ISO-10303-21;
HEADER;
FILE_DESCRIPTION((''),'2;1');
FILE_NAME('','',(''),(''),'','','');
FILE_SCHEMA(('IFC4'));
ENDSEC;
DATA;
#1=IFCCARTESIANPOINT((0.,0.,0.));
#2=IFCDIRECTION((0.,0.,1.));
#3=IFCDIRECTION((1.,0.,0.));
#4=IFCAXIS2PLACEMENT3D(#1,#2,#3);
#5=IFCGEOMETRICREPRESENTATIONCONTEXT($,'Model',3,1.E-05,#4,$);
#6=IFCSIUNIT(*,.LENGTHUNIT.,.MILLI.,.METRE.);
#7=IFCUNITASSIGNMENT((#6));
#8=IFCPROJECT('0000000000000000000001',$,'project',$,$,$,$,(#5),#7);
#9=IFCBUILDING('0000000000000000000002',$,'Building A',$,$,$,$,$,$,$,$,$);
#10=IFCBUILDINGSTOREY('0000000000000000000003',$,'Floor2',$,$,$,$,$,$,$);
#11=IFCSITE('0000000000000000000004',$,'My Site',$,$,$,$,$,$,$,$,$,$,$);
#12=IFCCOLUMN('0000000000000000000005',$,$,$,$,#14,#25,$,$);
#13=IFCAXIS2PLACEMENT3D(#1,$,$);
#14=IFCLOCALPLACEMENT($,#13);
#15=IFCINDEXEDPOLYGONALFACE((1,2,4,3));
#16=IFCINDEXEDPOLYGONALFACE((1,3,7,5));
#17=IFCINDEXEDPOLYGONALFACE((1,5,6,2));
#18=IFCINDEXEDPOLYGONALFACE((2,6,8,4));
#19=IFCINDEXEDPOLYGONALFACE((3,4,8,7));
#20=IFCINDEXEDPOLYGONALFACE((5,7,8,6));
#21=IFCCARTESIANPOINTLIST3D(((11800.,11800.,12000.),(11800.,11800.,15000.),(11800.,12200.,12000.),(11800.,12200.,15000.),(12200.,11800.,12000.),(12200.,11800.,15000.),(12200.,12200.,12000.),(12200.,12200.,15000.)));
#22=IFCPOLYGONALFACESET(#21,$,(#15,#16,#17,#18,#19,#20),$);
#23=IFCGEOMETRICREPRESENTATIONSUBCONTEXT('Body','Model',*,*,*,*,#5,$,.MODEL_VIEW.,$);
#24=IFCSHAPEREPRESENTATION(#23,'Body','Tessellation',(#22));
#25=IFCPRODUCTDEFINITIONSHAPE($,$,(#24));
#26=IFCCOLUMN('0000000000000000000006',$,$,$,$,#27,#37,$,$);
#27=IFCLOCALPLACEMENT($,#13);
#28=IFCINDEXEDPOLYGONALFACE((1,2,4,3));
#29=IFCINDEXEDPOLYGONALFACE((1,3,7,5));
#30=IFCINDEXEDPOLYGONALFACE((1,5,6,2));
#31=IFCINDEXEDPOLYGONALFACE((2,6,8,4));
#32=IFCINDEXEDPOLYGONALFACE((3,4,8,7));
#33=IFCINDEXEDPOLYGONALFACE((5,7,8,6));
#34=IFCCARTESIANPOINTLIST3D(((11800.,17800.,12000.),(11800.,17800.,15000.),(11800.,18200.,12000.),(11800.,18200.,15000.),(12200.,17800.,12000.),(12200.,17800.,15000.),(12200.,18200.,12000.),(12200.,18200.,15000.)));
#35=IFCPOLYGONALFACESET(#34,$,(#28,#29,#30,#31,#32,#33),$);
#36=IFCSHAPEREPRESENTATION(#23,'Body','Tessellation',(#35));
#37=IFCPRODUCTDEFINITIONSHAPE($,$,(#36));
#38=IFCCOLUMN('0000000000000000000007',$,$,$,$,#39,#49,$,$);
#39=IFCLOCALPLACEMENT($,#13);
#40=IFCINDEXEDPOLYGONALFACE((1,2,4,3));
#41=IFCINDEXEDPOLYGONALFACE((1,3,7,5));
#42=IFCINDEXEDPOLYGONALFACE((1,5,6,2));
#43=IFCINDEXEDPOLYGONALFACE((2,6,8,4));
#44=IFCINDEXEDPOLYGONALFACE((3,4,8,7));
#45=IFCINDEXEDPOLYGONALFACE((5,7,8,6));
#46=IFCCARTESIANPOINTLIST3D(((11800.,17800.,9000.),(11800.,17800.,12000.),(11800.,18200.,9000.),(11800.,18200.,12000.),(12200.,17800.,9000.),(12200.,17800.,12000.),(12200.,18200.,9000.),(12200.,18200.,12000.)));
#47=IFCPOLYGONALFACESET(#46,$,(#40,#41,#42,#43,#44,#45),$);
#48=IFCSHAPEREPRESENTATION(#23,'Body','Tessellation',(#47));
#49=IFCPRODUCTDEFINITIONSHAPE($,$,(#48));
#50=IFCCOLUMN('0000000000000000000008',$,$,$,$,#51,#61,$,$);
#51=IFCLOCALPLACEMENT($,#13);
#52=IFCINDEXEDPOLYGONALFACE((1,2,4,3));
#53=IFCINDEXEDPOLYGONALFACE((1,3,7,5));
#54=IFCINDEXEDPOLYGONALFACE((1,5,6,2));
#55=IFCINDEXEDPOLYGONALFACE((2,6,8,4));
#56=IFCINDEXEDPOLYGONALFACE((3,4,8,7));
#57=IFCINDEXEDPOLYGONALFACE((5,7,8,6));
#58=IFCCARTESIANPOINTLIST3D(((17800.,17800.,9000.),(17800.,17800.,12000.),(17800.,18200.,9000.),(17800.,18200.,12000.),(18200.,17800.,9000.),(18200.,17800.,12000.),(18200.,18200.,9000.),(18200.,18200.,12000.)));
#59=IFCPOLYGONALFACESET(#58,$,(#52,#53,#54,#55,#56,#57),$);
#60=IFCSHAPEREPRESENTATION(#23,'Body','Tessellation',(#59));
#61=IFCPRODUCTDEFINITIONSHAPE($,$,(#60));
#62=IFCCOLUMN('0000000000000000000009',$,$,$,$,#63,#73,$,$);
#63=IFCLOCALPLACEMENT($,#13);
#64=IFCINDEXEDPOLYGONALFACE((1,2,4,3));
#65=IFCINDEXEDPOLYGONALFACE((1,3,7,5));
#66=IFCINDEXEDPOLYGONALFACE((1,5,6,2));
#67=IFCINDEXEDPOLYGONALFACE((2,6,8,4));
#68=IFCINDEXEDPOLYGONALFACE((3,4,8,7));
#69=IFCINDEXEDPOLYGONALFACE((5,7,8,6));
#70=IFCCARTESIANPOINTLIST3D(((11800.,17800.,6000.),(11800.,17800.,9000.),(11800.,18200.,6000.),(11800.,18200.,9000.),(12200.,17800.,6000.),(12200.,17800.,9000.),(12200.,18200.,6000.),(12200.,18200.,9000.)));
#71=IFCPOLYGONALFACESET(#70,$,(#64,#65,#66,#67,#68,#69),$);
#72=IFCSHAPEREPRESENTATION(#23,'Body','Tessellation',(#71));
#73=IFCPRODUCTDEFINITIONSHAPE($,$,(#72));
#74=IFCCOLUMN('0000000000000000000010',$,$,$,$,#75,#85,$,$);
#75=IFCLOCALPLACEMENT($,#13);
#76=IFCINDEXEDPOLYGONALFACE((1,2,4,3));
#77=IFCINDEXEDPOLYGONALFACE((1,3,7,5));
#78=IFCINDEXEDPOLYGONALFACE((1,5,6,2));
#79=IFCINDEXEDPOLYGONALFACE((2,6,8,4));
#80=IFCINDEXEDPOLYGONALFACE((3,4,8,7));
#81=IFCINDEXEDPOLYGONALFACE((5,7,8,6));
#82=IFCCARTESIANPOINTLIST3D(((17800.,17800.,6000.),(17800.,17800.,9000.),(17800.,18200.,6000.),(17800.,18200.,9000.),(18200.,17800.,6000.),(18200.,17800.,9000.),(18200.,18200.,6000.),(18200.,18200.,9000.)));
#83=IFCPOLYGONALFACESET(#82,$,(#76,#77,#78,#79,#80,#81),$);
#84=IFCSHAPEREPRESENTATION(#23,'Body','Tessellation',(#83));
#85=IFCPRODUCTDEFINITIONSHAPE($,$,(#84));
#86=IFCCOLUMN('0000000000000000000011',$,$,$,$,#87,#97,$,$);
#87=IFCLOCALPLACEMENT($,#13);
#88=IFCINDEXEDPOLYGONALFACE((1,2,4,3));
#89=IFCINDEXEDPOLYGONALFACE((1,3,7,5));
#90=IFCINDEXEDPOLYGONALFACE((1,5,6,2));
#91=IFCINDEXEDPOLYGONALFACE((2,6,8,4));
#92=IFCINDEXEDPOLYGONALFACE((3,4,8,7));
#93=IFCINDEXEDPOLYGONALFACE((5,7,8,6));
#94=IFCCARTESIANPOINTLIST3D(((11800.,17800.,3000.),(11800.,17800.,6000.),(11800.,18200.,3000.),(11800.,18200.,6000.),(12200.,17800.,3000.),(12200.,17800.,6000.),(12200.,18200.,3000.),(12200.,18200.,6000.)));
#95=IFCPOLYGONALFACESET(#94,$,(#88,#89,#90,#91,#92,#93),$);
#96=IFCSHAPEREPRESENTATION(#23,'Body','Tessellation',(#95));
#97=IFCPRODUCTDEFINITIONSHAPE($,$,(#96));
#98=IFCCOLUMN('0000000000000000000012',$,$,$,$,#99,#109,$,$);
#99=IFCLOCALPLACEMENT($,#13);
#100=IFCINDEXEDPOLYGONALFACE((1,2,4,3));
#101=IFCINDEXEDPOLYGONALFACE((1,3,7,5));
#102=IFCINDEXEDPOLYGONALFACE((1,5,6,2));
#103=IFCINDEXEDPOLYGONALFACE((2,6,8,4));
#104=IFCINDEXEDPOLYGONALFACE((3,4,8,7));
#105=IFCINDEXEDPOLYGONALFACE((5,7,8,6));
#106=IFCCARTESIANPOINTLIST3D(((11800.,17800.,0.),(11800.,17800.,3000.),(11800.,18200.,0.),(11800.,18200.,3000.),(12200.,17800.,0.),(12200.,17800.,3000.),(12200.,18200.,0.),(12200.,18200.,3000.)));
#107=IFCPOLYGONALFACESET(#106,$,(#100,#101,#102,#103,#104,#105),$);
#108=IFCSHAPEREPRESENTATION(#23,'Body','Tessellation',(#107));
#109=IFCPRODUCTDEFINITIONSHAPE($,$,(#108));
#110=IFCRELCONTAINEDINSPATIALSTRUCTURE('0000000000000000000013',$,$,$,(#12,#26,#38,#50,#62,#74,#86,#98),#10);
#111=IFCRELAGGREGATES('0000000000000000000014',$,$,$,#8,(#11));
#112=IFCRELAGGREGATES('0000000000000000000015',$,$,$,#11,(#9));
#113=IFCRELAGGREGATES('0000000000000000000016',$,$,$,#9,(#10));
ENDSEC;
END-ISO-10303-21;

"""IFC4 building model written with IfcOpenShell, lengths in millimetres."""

from ifc_helpers import new_model, si_unit, frame, origin_with_axes, place, context, subcontext, project, spatial, line, indexed_curve, outline, extrude, element, save


model = new_model("IFC4")

# Units and contexts
model_context = context("Model", 3, precision=1e-05, world=origin_with_axes())
body_context = subcontext(model_context, "Body", "Model", "MODEL_VIEW")
ifc_project = project(units=[si_unit("LENGTHUNIT", "METRE", prefix="MILLI")], contexts=[model_context])

# Site, building, storey
site = spatial("IfcSite", under=ifc_project, Name="My Site")
building = spatial("IfcBuilding", under=site, Name="Building A")
storey = spatial("IfcBuildingStorey", under=building, Name="Floor2")

# Columns
for number, where, z_axis, x_axis in (
    (1, (12000.0, 12000.0, 12000.0), (0.0, 0.0, 1.0), (1.0, 0.0, 0.0)),
    (2, (12000.0, 18000.0, 12000.0), (0.0, 0.0, 1.0), (1.0, 0.0, 0.0)),
    (3, (12000.0, 18000.0, 9000.0), (0.0, 0.0, 1.0), (1.0, 0.0, 0.0)),
    (4, (18000.0, 18000.0, 9000.0), (0.0, 0.0, 1.0), (1.0, 0.0, 0.0)),
    (5, (12000.0, 18000.0, 6000.0), (0.0, 0.0, 1.0), (1.0, 0.0, 0.0)),
    (6, (18000.0, 18000.0, 6000.0), (0.0, 0.0, 1.0), (1.0, 0.0, 0.0)),
    (7, (12000.0, 18000.0, 3000.0), (0.0, 0.0, 1.0), (1.0, 0.0, 0.0)),
    (8, (12000.0, 18000.0, 0.0), (0.0, 0.0, 1.0), (1.0, 0.0, 0.0)),
):
    element("IfcColumn", number, at=place(None, frame(where, z_axis=z_axis, x_axis=x_axis)), inside=storey, context=body_context, shape_type="SweptSolid", body=[
        extrude(outline(indexed_curve([(-200.0, -200.0), (200.0, -200.0), (200.0, 200.0), (-200.0, 200.0)], segments=[line(1, 2, 3, 4, 1)])), origin_with_axes(), (0.0, 0.0, 1.0), 3000.0),
    ])

save(model, "model.ifc")
